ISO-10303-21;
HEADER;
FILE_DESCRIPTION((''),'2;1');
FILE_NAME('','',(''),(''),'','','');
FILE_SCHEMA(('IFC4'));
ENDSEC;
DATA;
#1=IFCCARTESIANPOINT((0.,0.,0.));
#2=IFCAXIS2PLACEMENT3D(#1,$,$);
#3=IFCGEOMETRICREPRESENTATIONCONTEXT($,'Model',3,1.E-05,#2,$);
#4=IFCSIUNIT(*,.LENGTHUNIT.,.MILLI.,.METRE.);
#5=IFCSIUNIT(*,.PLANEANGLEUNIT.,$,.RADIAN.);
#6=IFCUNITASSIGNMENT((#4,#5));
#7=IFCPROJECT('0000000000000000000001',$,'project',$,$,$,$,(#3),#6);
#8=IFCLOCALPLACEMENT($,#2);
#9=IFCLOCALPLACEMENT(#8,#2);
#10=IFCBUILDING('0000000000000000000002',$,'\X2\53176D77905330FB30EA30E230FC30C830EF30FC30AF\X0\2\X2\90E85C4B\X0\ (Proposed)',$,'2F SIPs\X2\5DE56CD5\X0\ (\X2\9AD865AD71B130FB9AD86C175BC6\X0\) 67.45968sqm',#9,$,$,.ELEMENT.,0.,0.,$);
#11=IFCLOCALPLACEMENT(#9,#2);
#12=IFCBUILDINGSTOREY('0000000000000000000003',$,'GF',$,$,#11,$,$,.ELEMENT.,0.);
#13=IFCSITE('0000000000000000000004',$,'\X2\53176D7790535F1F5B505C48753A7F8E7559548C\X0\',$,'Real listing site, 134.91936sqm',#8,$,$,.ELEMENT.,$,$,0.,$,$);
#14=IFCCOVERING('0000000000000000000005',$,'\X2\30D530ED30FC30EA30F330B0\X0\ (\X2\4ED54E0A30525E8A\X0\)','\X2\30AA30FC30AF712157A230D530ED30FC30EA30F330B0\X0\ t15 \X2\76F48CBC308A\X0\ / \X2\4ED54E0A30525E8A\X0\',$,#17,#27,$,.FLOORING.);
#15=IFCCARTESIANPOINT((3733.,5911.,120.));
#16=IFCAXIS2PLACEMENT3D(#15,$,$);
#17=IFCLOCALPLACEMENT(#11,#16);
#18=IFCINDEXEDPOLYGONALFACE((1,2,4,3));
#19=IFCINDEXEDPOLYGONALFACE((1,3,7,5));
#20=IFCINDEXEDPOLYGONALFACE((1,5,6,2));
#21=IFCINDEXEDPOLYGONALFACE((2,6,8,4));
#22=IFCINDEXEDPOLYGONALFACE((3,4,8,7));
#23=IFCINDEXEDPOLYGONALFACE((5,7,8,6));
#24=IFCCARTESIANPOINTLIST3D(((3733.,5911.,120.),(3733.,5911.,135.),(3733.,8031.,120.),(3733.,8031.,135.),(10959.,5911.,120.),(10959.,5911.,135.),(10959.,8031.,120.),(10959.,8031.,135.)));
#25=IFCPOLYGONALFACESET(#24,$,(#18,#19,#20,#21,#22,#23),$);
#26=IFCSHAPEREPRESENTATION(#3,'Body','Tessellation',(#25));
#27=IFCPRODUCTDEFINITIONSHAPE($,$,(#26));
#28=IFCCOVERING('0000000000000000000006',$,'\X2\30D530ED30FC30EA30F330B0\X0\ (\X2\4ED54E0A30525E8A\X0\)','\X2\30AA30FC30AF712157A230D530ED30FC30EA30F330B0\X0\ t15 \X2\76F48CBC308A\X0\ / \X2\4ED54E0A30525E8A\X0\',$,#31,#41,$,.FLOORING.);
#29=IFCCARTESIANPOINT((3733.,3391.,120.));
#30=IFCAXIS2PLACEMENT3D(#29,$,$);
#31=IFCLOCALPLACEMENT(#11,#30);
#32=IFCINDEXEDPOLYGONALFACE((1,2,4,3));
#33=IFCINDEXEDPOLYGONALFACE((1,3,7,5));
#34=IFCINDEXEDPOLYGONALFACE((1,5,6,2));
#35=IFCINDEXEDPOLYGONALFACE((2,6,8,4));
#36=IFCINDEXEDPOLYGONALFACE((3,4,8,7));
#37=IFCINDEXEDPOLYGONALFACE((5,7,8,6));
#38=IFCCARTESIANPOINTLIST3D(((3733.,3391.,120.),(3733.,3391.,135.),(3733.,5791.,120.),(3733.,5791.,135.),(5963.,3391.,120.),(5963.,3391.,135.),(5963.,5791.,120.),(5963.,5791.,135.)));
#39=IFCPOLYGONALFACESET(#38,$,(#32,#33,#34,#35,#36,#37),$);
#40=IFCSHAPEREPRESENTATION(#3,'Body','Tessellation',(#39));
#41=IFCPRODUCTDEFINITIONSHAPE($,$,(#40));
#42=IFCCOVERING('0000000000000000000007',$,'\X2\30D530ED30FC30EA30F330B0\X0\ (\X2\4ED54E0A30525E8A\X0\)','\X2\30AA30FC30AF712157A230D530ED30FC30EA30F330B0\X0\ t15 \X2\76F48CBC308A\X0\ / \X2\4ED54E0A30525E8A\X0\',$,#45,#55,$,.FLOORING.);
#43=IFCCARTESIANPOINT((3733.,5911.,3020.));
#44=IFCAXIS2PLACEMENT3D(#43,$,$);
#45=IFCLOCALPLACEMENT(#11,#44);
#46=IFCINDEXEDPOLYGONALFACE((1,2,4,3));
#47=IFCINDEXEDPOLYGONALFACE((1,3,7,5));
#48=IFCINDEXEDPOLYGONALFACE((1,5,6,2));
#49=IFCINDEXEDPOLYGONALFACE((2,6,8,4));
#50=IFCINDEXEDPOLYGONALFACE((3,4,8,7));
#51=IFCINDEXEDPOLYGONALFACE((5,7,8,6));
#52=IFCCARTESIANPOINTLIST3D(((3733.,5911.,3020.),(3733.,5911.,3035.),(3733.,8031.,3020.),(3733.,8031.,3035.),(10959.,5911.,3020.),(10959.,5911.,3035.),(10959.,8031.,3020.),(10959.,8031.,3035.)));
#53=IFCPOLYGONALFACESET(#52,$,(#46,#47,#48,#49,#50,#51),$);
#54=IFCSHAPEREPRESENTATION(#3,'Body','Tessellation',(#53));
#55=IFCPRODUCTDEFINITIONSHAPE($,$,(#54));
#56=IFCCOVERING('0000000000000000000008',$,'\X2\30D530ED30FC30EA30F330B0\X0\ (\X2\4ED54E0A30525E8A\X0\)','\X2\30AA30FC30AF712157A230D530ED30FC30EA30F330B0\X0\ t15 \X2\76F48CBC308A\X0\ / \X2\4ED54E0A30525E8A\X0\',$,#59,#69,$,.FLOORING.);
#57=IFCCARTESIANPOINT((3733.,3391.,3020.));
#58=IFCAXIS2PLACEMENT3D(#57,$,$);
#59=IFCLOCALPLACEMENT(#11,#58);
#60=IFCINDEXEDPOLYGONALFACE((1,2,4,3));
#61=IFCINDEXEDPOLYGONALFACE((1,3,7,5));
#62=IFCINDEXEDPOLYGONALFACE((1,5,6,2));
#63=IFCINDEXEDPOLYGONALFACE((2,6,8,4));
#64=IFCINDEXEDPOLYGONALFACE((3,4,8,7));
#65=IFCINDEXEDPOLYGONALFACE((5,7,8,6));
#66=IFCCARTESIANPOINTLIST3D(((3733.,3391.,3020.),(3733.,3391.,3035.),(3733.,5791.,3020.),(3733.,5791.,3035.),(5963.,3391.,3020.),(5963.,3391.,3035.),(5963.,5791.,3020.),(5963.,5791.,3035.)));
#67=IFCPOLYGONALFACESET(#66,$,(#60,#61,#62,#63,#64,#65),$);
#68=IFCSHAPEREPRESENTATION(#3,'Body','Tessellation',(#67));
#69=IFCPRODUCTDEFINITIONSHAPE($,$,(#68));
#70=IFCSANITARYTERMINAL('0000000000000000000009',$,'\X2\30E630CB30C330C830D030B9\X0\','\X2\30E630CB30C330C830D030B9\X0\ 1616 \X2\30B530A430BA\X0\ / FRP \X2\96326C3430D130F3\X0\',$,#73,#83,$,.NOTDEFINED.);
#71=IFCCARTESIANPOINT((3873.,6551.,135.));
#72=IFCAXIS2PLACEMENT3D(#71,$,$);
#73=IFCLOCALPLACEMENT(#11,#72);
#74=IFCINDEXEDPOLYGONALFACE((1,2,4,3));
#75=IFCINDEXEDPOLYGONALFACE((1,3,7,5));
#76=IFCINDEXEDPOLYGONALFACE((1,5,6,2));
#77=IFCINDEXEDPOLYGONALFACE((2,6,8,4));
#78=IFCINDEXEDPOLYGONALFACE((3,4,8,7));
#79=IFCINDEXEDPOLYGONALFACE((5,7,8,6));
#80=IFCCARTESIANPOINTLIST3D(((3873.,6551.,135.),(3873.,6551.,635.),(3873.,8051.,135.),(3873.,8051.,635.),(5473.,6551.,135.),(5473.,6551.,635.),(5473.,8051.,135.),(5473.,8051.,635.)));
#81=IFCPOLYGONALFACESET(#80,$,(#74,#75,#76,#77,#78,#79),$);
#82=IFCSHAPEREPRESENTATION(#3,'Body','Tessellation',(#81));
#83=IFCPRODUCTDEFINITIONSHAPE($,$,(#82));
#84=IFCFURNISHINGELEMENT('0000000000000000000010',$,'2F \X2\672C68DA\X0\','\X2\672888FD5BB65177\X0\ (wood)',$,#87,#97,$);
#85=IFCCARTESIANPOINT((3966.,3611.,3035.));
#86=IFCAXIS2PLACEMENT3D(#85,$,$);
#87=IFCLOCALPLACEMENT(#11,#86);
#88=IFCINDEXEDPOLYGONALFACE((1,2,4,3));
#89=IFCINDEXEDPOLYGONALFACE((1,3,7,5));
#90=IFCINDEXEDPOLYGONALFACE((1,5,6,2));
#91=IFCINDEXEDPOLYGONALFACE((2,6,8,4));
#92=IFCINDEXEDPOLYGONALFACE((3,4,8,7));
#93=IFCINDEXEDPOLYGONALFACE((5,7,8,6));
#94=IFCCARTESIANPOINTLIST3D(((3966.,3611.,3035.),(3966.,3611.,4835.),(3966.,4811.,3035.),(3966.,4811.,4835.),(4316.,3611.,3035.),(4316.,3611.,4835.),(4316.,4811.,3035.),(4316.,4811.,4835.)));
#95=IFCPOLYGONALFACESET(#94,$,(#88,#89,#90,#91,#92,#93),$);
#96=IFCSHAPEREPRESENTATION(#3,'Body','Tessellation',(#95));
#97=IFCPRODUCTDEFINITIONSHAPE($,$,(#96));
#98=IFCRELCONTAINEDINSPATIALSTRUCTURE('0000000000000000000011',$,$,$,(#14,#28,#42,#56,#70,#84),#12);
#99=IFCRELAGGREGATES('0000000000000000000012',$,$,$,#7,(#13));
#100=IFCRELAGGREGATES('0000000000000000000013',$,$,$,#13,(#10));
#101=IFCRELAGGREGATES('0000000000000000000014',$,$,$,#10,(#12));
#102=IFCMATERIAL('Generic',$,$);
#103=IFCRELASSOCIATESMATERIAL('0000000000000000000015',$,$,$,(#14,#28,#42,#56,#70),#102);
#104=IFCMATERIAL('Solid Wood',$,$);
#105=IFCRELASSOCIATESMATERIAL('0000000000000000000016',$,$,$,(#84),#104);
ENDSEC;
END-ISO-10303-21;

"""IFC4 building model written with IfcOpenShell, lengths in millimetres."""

from ifc_helpers import new_model, si_unit, frame, frame_2d, origin, place, context, project, spatial, rectangle, extrude, material, element, save


model = new_model("IFC4")

# Units and contexts
model_context = context("Model", 3, precision=1e-05, world=origin())
ifc_project = project(units=[si_unit("LENGTHUNIT", "METRE", prefix="MILLI"), si_unit("PLANEANGLEUNIT", "RADIAN")], contexts=[model_context])

# Site, building, storey
site_placement = place(None, origin())
site = spatial("IfcSite", under=ifc_project, at=site_placement, Name="北海道弟子屈町美留和", ObjectType="Real listing site, 134.91936sqm", CompositionType="ELEMENT", RefElevation=0.0)
building_placement = place(site_placement, origin())
building = spatial("IfcBuilding", under=site, at=building_placement, Name="北海道・リモートワーク2部屋 (Proposed)", ObjectType="2F SIPs工法 (高断熱・高気密) 67.45968sqm", CompositionType="ELEMENT", ElevationOfRefHeight=0.0, ElevationOfTerrain=0.0)
storey_placement = place(building_placement, origin())
storey = spatial("IfcBuildingStorey", under=building, at=storey_placement, Name="GF", CompositionType="ELEMENT", Elevation=0.0)

# Shared definitions
ifc_material_1 = material(Name="Solid Wood")

# Coverings
ifc_material_2 = material(Name="Generic")
covering_1_placement = place(storey_placement, frame((3733.0, 5911.0, 120.0)))
element("IfcCovering", 1, at=covering_1_placement, inside=storey, material=ifc_material_2, Name="フローリング (仕上げ床)", Description="オーク無垢フローリング t15 直貼り / 仕上げ床", PredefinedType="FLOORING", context=model_context, shape_type="SweptSolid", body=[
    extrude(rectangle(XDim=7226.0, YDim=2120.0, at=frame_2d((3613.0, 1060.0))), frame((3733.0, 5911.0, 120.0)), (0.0, 0.0, 1.0), 15.0),
])
covering_2_placement = place(storey_placement, frame((3733.0, 3391.0, 120.0)))
element("IfcCovering", 2, at=covering_2_placement, inside=storey, material=ifc_material_2, Name="フローリング (仕上げ床)", Description="オーク無垢フローリング t15 直貼り / 仕上げ床", PredefinedType="FLOORING", context=model_context, shape_type="SweptSolid", body=[
    extrude(rectangle(XDim=2230.0, YDim=2400.0, at=frame_2d((1115.0, 1200.0))), frame((3733.0, 3391.0, 120.0)), (0.0, 0.0, 1.0), 15.0),
])
covering_3_placement = place(storey_placement, frame((3733.0, 5911.0, 3020.0)))
element("IfcCovering", 3, at=covering_3_placement, inside=storey, material=ifc_material_2, Name="フローリング (仕上げ床)", Description="オーク無垢フローリング t15 直貼り / 仕上げ床", PredefinedType="FLOORING", context=model_context, shape_type="SweptSolid", body=[
    extrude(rectangle(XDim=7226.0, YDim=2120.0, at=frame_2d((3613.0, 1060.0))), frame((3733.0, 5911.0, 3020.0)), (0.0, 0.0, 1.0), 15.0),
])
covering_4_placement = place(storey_placement, frame((3733.0, 3391.0, 3020.0)))
element("IfcCovering", 4, at=covering_4_placement, inside=storey, material=ifc_material_2, Name="フローリング (仕上げ床)", Description="オーク無垢フローリング t15 直貼り / 仕上げ床", PredefinedType="FLOORING", context=model_context, shape_type="SweptSolid", body=[
    extrude(rectangle(XDim=2230.0, YDim=2400.0, at=frame_2d((1115.0, 1200.0))), frame((3733.0, 3391.0, 3020.0)), (0.0, 0.0, 1.0), 15.0),
])

# Sanitary terminal
sanitary_terminal_placement = place(storey_placement, frame((3873.0, 6551.0, 135.0)))
element("IfcSanitaryTerminal", 5, at=sanitary_terminal_placement, inside=storey, material=ifc_material_2, Name="ユニットバス", Description="ユニットバス 1616 サイズ / FRP 防水パン", PredefinedType="NOTDEFINED", context=model_context, shape_type="SweptSolid", body=[
    extrude(rectangle(XDim=1600.0, YDim=1500.0, at=frame_2d((800.0, 750.0))), frame((3873.0, 6551.0, 135.0)), (0.0, 0.0, 1.0), 500.0),
])

# Furnishing element
furnishing_placement = place(storey_placement, frame((3966.0, 3611.0, 3035.0)))
element("IfcFurnishingElement", 6, at=furnishing_placement, inside=storey, material=ifc_material_1, Name="2F 本棚", Description="木製家具 (wood)", context=model_context, shape_type="SweptSolid", body=[
    extrude(rectangle(XDim=350.0, YDim=1200.0, at=frame_2d((175.0, 600.0))), frame((3966.0, 3611.0, 3035.0)), (0.0, 0.0, 1.0), 1800.0),
])

save(model, "model.ifc")
